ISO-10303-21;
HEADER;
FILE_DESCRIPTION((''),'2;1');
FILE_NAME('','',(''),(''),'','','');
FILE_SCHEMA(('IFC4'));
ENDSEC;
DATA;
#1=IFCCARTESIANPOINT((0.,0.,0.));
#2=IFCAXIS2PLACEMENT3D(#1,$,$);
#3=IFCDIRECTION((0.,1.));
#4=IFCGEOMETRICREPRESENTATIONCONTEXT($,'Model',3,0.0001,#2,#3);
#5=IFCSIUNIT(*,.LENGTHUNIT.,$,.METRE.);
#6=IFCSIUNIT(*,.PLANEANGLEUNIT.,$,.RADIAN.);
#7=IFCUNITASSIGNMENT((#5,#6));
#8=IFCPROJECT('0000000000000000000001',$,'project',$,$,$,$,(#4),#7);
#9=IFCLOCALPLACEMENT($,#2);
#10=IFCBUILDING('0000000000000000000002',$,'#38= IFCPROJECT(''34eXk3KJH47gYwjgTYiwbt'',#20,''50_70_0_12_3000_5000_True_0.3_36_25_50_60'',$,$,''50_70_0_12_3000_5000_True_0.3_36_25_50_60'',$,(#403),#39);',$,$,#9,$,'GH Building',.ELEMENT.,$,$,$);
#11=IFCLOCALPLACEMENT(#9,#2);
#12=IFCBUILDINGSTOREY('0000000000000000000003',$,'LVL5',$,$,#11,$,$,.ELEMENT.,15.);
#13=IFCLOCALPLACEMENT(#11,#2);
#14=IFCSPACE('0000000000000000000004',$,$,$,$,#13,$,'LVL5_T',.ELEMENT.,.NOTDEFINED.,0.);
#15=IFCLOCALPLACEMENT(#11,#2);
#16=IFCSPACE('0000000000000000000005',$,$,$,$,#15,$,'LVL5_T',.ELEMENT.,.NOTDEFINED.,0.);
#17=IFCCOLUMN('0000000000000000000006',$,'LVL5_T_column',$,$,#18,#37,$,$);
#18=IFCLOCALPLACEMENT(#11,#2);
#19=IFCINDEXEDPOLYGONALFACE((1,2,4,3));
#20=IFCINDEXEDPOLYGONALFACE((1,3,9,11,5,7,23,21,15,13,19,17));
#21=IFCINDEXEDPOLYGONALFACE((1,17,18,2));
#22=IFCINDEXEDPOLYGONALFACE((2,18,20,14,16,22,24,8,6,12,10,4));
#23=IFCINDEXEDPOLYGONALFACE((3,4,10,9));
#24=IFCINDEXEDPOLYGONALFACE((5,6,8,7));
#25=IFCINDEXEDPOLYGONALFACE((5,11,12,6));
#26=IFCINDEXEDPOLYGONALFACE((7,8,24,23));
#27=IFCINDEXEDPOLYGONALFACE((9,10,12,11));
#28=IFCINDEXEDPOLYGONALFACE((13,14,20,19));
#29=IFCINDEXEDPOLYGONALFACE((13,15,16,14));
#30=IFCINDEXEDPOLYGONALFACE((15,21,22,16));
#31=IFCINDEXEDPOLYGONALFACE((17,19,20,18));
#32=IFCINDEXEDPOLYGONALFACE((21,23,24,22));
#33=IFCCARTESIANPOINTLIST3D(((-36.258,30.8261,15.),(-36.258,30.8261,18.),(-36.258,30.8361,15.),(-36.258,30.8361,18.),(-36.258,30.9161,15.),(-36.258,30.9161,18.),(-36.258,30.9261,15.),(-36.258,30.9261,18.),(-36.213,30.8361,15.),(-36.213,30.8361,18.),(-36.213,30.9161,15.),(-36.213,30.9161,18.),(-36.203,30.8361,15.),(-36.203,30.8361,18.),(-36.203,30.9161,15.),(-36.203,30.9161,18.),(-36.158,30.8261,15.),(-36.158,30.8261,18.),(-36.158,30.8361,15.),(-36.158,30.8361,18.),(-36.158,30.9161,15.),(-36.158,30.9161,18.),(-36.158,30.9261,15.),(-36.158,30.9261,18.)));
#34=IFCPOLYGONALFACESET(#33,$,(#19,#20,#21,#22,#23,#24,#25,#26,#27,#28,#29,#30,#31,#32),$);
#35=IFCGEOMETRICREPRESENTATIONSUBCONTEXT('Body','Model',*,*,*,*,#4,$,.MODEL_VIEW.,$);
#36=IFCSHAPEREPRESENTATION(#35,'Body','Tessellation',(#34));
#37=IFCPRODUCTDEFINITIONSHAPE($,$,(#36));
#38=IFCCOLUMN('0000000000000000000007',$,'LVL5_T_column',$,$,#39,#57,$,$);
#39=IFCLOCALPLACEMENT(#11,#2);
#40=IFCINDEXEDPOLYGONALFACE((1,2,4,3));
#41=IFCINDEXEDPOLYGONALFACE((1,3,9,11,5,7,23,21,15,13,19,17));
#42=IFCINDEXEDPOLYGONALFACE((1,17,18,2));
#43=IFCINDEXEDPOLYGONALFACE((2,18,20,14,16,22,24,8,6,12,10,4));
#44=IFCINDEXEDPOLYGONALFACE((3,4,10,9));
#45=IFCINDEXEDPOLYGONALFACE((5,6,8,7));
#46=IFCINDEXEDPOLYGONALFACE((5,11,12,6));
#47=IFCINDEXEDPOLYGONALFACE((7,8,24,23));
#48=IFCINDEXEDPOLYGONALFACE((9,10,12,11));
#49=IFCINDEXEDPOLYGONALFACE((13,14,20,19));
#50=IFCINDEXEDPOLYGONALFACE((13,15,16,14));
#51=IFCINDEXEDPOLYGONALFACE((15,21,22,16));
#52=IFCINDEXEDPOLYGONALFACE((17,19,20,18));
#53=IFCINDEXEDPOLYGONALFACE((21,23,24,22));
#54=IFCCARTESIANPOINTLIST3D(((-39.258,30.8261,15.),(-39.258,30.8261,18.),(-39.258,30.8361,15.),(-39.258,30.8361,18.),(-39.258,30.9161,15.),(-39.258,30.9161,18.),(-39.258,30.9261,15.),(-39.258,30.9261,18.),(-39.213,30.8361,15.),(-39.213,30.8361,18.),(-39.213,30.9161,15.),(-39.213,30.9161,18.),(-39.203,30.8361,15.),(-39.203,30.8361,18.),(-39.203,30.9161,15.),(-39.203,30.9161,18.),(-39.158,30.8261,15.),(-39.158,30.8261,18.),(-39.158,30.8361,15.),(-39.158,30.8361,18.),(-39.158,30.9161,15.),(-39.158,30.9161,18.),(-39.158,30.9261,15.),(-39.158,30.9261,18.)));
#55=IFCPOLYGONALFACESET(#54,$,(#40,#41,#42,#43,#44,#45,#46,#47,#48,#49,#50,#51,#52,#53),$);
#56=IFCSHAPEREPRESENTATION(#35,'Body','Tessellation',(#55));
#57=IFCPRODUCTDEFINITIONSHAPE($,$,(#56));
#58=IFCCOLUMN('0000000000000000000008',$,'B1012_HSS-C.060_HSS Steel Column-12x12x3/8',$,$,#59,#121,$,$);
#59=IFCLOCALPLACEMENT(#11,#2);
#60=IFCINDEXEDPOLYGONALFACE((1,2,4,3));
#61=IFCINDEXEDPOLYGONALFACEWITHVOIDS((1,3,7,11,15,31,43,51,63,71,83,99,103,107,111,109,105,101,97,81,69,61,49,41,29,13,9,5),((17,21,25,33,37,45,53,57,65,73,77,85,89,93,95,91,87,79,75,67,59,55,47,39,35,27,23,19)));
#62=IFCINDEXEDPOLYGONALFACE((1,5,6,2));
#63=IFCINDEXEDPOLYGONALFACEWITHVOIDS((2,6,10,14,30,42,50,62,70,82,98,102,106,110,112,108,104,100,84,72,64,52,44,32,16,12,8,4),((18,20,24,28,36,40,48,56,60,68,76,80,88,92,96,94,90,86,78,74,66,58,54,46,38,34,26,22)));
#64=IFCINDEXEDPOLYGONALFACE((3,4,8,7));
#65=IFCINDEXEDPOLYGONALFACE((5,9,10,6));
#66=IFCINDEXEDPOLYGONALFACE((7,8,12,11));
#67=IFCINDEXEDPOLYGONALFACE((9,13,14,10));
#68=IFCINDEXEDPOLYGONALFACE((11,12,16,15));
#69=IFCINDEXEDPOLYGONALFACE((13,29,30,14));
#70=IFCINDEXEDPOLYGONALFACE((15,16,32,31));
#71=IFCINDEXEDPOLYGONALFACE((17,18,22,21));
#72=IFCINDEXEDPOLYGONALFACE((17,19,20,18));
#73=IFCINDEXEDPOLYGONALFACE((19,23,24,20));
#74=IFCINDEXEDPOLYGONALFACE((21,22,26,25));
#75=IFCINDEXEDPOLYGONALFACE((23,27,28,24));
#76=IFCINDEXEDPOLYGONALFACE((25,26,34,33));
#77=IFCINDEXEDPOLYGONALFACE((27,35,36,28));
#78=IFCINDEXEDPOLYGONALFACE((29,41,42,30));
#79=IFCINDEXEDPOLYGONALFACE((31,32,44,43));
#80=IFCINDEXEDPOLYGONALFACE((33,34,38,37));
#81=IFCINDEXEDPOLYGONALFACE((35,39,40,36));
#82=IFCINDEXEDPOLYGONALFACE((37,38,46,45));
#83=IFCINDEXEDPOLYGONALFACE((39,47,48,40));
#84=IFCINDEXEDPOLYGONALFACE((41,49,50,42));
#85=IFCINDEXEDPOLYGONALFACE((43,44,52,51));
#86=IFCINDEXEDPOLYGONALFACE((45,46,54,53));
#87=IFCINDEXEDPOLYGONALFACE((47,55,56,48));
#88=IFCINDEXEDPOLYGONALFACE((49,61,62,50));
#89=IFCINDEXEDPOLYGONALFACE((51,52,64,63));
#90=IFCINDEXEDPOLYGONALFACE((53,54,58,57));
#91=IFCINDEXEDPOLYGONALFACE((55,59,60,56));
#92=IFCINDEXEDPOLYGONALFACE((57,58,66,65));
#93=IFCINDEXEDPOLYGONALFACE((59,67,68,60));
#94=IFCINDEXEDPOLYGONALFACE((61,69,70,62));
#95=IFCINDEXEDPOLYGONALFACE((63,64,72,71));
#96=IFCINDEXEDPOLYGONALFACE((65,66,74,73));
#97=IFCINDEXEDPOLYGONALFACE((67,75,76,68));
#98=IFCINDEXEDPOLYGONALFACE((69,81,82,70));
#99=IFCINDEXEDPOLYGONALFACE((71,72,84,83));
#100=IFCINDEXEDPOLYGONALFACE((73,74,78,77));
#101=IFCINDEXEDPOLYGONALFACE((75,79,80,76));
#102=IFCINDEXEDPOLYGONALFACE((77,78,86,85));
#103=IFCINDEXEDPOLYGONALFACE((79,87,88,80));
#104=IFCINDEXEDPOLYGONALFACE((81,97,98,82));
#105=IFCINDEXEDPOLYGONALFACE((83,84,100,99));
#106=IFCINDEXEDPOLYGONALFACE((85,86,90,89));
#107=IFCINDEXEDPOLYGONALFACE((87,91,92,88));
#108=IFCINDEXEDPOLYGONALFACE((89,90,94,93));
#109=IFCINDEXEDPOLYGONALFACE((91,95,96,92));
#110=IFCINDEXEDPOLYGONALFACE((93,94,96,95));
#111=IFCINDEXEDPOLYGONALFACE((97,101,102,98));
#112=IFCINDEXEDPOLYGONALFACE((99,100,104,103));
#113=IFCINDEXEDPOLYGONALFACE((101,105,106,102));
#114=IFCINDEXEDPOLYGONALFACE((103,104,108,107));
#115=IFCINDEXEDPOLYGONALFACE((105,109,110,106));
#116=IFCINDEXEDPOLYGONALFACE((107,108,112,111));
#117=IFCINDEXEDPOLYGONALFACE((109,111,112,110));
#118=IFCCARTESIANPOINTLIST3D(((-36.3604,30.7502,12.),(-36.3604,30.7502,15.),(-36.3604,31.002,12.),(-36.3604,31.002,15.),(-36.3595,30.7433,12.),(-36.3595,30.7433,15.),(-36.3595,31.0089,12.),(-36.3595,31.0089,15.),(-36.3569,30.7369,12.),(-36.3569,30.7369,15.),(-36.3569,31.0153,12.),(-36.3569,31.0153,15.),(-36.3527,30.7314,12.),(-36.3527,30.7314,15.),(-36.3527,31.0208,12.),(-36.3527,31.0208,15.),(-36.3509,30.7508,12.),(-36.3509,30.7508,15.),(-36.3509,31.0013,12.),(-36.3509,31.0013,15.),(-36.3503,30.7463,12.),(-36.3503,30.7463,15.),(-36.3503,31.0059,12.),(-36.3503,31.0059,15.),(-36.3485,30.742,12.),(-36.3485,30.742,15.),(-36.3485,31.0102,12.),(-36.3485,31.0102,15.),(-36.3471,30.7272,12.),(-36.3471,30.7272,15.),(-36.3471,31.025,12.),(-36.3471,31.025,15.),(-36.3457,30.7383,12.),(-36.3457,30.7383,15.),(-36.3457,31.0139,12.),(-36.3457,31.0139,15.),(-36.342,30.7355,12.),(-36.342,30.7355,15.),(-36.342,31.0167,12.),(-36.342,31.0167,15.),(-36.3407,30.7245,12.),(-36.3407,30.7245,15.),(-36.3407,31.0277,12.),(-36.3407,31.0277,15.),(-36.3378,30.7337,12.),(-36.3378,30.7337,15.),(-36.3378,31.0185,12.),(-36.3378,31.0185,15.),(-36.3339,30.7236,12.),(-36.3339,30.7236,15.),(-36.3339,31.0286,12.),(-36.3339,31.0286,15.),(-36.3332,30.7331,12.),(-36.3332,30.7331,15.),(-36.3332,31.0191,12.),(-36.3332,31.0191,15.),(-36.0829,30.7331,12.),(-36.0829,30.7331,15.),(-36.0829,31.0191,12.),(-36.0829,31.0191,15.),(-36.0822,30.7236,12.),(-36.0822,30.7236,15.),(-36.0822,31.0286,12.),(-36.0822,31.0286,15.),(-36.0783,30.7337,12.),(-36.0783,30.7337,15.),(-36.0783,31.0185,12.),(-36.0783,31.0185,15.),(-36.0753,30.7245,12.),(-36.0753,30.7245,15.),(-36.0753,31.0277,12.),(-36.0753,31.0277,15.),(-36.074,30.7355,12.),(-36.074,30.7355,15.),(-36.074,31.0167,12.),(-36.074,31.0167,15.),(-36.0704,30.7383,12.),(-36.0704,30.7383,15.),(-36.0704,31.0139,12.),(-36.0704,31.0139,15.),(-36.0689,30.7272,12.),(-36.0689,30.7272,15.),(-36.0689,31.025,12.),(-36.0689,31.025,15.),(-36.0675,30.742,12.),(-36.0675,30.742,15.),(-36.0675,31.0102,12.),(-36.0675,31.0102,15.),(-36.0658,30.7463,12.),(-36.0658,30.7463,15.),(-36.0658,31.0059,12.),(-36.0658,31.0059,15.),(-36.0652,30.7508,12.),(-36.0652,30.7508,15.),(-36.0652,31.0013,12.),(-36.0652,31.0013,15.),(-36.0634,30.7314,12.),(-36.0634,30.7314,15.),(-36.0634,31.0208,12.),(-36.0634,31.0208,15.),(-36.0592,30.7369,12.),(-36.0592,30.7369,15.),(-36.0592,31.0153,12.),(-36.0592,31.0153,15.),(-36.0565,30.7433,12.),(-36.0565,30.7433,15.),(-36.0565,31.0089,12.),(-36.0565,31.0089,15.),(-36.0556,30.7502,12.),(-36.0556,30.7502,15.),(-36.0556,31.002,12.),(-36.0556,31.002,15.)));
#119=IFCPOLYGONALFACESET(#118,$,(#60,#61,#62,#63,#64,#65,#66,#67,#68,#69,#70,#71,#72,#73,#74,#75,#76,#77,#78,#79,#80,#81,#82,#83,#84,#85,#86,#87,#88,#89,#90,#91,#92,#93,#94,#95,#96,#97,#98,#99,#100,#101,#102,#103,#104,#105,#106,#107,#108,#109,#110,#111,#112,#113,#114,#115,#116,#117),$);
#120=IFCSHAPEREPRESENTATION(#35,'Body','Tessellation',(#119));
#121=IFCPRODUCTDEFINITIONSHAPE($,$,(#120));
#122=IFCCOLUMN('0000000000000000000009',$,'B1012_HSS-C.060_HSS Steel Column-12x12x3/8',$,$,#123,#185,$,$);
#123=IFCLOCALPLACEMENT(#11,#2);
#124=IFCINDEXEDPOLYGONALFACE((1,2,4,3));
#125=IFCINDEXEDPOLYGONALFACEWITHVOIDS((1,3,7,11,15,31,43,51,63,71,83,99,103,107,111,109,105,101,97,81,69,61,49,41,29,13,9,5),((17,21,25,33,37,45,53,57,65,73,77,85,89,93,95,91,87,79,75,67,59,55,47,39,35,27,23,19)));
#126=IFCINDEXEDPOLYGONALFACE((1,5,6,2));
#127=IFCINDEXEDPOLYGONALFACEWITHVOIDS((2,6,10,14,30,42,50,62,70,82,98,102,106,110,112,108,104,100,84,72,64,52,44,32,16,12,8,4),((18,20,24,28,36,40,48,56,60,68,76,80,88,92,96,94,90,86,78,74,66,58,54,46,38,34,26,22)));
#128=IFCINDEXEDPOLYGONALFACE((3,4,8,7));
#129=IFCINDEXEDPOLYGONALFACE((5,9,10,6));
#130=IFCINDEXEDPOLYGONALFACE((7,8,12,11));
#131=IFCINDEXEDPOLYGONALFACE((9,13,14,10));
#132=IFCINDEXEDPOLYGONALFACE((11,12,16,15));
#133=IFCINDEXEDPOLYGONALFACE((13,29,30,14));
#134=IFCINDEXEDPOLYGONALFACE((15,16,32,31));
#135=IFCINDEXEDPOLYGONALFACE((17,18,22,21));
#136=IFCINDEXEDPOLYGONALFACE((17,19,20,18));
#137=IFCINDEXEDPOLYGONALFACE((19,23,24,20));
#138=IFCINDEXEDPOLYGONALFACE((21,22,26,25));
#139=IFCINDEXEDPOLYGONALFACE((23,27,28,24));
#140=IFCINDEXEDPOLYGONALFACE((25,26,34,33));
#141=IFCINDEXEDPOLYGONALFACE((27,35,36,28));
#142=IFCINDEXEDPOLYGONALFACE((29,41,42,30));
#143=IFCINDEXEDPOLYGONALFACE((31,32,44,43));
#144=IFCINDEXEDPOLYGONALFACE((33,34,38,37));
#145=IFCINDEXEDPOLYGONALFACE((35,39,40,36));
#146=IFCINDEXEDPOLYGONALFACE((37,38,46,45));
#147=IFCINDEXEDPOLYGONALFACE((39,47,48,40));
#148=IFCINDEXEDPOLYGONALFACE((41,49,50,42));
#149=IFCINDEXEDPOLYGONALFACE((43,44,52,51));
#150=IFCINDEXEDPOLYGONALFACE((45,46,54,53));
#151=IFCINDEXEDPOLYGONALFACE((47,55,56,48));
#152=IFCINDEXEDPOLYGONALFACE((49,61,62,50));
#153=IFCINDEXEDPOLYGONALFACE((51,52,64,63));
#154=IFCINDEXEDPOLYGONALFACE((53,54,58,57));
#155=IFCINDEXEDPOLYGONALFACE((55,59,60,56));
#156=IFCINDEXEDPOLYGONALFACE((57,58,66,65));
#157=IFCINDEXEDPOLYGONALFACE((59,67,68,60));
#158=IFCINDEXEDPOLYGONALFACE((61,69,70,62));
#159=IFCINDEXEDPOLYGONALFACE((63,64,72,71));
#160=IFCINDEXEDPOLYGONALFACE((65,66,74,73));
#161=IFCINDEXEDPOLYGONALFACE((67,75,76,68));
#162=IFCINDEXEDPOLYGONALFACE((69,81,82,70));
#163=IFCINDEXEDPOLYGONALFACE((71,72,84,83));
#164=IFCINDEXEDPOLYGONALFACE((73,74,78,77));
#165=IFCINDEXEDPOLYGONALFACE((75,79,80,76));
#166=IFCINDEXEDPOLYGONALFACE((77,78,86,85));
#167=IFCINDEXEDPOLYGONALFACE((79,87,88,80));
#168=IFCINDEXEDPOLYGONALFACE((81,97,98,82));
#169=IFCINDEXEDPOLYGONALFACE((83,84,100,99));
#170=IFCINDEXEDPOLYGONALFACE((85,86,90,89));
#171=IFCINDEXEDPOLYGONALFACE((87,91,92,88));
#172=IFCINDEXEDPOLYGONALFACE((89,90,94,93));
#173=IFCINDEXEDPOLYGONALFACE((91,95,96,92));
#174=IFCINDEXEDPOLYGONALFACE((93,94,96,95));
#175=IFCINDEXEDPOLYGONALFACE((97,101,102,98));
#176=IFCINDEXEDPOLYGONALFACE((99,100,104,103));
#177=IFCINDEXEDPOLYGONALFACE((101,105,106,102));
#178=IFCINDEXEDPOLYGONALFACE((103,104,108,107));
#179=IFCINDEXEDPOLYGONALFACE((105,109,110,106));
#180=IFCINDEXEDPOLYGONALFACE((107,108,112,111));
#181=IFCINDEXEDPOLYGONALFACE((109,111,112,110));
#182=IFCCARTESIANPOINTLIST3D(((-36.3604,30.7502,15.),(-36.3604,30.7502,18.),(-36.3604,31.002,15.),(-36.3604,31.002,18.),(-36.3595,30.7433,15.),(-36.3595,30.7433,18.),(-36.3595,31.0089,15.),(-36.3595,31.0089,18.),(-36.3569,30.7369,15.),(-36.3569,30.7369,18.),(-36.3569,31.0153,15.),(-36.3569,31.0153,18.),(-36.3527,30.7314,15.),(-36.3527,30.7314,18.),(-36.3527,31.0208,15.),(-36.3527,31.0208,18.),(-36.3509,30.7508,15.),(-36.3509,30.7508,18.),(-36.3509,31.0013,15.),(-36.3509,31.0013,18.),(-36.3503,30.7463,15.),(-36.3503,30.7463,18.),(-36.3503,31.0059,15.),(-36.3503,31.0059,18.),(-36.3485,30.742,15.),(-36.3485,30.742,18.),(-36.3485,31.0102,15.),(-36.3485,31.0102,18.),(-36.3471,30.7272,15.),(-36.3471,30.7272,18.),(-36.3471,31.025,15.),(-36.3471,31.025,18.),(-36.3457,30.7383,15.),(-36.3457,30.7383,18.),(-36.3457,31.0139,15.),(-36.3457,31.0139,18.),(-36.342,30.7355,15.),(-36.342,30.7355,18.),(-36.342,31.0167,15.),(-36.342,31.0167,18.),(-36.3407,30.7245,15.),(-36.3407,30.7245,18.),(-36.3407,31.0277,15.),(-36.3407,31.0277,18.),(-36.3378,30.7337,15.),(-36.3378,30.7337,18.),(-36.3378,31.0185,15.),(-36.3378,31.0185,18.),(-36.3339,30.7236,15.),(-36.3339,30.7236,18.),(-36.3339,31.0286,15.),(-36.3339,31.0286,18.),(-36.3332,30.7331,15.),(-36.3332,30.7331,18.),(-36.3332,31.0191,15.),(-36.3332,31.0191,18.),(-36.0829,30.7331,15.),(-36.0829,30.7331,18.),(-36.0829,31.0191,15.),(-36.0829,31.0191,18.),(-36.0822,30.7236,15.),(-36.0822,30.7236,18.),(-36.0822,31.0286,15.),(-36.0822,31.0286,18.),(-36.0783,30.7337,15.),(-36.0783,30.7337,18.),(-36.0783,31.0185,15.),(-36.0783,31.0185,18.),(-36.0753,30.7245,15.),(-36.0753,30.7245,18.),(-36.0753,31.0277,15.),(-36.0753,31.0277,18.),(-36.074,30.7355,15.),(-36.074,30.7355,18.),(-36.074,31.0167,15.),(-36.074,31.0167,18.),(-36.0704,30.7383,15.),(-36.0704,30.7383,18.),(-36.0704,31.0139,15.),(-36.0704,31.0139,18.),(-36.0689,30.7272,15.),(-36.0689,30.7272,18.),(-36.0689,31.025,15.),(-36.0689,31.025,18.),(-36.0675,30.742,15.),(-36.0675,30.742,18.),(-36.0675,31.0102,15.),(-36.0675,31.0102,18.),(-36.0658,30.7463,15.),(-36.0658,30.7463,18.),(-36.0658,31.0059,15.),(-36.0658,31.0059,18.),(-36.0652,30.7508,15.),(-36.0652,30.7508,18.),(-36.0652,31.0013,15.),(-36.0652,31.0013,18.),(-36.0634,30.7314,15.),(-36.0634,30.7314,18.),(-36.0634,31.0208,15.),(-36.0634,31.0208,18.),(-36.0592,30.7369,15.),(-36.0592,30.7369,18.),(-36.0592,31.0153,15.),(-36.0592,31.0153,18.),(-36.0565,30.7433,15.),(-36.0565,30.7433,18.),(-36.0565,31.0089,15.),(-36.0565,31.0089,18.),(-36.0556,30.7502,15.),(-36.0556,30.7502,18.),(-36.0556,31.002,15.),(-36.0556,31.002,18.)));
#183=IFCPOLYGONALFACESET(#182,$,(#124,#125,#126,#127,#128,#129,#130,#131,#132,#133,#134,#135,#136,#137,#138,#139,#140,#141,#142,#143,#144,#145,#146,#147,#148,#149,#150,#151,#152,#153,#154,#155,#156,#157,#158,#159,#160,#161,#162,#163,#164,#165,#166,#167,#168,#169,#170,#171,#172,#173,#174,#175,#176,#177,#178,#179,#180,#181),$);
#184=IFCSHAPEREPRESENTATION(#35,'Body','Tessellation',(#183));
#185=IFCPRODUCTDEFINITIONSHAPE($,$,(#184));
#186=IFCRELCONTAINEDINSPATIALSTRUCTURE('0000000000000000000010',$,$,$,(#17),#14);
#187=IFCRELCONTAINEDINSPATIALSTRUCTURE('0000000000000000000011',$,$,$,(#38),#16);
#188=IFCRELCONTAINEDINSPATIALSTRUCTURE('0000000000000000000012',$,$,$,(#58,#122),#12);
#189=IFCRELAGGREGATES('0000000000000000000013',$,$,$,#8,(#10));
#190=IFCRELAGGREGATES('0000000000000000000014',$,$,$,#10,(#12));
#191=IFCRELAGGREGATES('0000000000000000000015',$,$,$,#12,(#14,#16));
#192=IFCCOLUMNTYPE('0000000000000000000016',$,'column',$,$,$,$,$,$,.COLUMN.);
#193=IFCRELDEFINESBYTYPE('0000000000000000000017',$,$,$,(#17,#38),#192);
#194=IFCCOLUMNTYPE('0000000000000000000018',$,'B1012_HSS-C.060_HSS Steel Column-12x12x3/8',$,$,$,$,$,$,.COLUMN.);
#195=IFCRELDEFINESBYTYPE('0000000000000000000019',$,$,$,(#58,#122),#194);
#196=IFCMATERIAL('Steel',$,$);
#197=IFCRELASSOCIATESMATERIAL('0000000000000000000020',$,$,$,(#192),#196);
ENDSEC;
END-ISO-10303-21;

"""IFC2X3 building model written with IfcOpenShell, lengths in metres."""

from ifc_helpers import new_model, si_unit, direction, frame, origin, origin_2d, place, context, subcontext, project, spatial, hollow_rectangle, i_section, extrude, material, type_object, element, save


model = new_model("IFC2X3")

# Units and contexts
model_context = context("Model", 3, precision=0.0001, world=origin(), true_north=direction((0.0, 1.0)))
body_context = subcontext(model_context, "Body", "Model", "MODEL_VIEW")
ifc_project = project(units=[si_unit("LENGTHUNIT", "METRE"), si_unit("PLANEANGLEUNIT", "RADIAN")], contexts=[model_context])

# Building, storey, space
building_placement = place(None, origin())
building = spatial("IfcBuilding", under=ifc_project, at=building_placement, Name="#38= IFCPROJECT('34eXk3KJH47gYwjgTYiwbt',#20,'50_70_0_12_3000_5000_True_0.3_36_25_50_60',$,$,'50_70_0_12_3000_5000_True_0.3_36_25_50_60',$,(#403),#39);", LongName="GH Building", CompositionType="ELEMENT")
storey_placement = place(building_placement, origin())
storey = spatial("IfcBuildingStorey", under=building, at=storey_placement, Name="LVL5", CompositionType="ELEMENT", Elevation=15.0)
space_1_placement = place(storey_placement, origin())
space_1 = spatial("IfcSpace", under=storey, at=space_1_placement, LongName="LVL5_T", CompositionType="ELEMENT", InteriorOrExteriorSpace="NOTDEFINED", ElevationWithFlooring=0.0)

# Column
ifc_material_1 = material(Name="Steel")
column_type_1 = type_object("IfcColumnType", Name="column", PredefinedType="COLUMN", material=ifc_material_1)
for number, where, name in (
    (1, (-36.208, 30.8761, 15.0), "LVL5_T_column"),
):
    element("IfcColumn", number, at=place(space_1_placement, frame(where)), inside=space_1, type_object=column_type_1, Name=name, context=body_context, shape_type="SweptSolid", body=[
        extrude(i_section(OverallWidth=0.1, OverallDepth=0.1, WebThickness=0.01, FlangeThickness=0.01, at=origin_2d()), origin(), (0.0, 0.0, 1.0), 3.0),
    ])

# Shared definitions
space_2_placement = place(storey_placement, origin())
space_2 = spatial("IfcSpace", under=storey, at=space_2_placement, LongName="LVL5_T", CompositionType="ELEMENT", InteriorOrExteriorSpace="NOTDEFINED", ElevationWithFlooring=0.0)

# Columns
for number, where, name in (
    (2, (-39.208, 30.8761, 15.0), "LVL5_T_column"),
):
    element("IfcColumn", number, at=place(space_2_placement, frame(where)), inside=space_2, type_object=column_type_1, Name=name, context=body_context, shape_type="SweptSolid", body=[
        extrude(i_section(OverallWidth=0.1, OverallDepth=0.1, WebThickness=0.01, FlangeThickness=0.01, at=origin_2d()), origin(), (0.0, 0.0, 1.0), 3.0),
    ])
column_type_2 = type_object("IfcColumnType", Name="B1012_HSS-C.060_HSS Steel Column-12x12x3/8", PredefinedType="COLUMN")
for number, where, z_axis, x_axis, name in (
    (3, (-36.208, 30.8761, 15.0), (0.0, 0.0, -1.0), (-1.0, 0.0, 0.0), "B1012_HSS-C.060_HSS Steel Column-12x12x3/8"),
    (4, (-36.208, 30.8761, 18.0), (0.0, 0.0, -1.0), (-1.0, 0.0, 0.0), "B1012_HSS-C.060_HSS Steel Column-12x12x3/8"),
):
    element("IfcColumn", number, at=place(storey_placement, frame(where, z_axis=z_axis, x_axis=x_axis)), inside=storey, type_object=column_type_2, Name=name, context=body_context, shape_type="SweptSolid", body=[
        extrude(hollow_rectangle(XDim=0.3048, YDim=0.305, WallThickness=0.0095, InnerFilletRadius=0.0177, OuterFilletRadius=0.0266, at=origin_2d()), origin(), (0.0, 0.0, 1.0), 3.0),
    ])

save(model, "model.ifc")
